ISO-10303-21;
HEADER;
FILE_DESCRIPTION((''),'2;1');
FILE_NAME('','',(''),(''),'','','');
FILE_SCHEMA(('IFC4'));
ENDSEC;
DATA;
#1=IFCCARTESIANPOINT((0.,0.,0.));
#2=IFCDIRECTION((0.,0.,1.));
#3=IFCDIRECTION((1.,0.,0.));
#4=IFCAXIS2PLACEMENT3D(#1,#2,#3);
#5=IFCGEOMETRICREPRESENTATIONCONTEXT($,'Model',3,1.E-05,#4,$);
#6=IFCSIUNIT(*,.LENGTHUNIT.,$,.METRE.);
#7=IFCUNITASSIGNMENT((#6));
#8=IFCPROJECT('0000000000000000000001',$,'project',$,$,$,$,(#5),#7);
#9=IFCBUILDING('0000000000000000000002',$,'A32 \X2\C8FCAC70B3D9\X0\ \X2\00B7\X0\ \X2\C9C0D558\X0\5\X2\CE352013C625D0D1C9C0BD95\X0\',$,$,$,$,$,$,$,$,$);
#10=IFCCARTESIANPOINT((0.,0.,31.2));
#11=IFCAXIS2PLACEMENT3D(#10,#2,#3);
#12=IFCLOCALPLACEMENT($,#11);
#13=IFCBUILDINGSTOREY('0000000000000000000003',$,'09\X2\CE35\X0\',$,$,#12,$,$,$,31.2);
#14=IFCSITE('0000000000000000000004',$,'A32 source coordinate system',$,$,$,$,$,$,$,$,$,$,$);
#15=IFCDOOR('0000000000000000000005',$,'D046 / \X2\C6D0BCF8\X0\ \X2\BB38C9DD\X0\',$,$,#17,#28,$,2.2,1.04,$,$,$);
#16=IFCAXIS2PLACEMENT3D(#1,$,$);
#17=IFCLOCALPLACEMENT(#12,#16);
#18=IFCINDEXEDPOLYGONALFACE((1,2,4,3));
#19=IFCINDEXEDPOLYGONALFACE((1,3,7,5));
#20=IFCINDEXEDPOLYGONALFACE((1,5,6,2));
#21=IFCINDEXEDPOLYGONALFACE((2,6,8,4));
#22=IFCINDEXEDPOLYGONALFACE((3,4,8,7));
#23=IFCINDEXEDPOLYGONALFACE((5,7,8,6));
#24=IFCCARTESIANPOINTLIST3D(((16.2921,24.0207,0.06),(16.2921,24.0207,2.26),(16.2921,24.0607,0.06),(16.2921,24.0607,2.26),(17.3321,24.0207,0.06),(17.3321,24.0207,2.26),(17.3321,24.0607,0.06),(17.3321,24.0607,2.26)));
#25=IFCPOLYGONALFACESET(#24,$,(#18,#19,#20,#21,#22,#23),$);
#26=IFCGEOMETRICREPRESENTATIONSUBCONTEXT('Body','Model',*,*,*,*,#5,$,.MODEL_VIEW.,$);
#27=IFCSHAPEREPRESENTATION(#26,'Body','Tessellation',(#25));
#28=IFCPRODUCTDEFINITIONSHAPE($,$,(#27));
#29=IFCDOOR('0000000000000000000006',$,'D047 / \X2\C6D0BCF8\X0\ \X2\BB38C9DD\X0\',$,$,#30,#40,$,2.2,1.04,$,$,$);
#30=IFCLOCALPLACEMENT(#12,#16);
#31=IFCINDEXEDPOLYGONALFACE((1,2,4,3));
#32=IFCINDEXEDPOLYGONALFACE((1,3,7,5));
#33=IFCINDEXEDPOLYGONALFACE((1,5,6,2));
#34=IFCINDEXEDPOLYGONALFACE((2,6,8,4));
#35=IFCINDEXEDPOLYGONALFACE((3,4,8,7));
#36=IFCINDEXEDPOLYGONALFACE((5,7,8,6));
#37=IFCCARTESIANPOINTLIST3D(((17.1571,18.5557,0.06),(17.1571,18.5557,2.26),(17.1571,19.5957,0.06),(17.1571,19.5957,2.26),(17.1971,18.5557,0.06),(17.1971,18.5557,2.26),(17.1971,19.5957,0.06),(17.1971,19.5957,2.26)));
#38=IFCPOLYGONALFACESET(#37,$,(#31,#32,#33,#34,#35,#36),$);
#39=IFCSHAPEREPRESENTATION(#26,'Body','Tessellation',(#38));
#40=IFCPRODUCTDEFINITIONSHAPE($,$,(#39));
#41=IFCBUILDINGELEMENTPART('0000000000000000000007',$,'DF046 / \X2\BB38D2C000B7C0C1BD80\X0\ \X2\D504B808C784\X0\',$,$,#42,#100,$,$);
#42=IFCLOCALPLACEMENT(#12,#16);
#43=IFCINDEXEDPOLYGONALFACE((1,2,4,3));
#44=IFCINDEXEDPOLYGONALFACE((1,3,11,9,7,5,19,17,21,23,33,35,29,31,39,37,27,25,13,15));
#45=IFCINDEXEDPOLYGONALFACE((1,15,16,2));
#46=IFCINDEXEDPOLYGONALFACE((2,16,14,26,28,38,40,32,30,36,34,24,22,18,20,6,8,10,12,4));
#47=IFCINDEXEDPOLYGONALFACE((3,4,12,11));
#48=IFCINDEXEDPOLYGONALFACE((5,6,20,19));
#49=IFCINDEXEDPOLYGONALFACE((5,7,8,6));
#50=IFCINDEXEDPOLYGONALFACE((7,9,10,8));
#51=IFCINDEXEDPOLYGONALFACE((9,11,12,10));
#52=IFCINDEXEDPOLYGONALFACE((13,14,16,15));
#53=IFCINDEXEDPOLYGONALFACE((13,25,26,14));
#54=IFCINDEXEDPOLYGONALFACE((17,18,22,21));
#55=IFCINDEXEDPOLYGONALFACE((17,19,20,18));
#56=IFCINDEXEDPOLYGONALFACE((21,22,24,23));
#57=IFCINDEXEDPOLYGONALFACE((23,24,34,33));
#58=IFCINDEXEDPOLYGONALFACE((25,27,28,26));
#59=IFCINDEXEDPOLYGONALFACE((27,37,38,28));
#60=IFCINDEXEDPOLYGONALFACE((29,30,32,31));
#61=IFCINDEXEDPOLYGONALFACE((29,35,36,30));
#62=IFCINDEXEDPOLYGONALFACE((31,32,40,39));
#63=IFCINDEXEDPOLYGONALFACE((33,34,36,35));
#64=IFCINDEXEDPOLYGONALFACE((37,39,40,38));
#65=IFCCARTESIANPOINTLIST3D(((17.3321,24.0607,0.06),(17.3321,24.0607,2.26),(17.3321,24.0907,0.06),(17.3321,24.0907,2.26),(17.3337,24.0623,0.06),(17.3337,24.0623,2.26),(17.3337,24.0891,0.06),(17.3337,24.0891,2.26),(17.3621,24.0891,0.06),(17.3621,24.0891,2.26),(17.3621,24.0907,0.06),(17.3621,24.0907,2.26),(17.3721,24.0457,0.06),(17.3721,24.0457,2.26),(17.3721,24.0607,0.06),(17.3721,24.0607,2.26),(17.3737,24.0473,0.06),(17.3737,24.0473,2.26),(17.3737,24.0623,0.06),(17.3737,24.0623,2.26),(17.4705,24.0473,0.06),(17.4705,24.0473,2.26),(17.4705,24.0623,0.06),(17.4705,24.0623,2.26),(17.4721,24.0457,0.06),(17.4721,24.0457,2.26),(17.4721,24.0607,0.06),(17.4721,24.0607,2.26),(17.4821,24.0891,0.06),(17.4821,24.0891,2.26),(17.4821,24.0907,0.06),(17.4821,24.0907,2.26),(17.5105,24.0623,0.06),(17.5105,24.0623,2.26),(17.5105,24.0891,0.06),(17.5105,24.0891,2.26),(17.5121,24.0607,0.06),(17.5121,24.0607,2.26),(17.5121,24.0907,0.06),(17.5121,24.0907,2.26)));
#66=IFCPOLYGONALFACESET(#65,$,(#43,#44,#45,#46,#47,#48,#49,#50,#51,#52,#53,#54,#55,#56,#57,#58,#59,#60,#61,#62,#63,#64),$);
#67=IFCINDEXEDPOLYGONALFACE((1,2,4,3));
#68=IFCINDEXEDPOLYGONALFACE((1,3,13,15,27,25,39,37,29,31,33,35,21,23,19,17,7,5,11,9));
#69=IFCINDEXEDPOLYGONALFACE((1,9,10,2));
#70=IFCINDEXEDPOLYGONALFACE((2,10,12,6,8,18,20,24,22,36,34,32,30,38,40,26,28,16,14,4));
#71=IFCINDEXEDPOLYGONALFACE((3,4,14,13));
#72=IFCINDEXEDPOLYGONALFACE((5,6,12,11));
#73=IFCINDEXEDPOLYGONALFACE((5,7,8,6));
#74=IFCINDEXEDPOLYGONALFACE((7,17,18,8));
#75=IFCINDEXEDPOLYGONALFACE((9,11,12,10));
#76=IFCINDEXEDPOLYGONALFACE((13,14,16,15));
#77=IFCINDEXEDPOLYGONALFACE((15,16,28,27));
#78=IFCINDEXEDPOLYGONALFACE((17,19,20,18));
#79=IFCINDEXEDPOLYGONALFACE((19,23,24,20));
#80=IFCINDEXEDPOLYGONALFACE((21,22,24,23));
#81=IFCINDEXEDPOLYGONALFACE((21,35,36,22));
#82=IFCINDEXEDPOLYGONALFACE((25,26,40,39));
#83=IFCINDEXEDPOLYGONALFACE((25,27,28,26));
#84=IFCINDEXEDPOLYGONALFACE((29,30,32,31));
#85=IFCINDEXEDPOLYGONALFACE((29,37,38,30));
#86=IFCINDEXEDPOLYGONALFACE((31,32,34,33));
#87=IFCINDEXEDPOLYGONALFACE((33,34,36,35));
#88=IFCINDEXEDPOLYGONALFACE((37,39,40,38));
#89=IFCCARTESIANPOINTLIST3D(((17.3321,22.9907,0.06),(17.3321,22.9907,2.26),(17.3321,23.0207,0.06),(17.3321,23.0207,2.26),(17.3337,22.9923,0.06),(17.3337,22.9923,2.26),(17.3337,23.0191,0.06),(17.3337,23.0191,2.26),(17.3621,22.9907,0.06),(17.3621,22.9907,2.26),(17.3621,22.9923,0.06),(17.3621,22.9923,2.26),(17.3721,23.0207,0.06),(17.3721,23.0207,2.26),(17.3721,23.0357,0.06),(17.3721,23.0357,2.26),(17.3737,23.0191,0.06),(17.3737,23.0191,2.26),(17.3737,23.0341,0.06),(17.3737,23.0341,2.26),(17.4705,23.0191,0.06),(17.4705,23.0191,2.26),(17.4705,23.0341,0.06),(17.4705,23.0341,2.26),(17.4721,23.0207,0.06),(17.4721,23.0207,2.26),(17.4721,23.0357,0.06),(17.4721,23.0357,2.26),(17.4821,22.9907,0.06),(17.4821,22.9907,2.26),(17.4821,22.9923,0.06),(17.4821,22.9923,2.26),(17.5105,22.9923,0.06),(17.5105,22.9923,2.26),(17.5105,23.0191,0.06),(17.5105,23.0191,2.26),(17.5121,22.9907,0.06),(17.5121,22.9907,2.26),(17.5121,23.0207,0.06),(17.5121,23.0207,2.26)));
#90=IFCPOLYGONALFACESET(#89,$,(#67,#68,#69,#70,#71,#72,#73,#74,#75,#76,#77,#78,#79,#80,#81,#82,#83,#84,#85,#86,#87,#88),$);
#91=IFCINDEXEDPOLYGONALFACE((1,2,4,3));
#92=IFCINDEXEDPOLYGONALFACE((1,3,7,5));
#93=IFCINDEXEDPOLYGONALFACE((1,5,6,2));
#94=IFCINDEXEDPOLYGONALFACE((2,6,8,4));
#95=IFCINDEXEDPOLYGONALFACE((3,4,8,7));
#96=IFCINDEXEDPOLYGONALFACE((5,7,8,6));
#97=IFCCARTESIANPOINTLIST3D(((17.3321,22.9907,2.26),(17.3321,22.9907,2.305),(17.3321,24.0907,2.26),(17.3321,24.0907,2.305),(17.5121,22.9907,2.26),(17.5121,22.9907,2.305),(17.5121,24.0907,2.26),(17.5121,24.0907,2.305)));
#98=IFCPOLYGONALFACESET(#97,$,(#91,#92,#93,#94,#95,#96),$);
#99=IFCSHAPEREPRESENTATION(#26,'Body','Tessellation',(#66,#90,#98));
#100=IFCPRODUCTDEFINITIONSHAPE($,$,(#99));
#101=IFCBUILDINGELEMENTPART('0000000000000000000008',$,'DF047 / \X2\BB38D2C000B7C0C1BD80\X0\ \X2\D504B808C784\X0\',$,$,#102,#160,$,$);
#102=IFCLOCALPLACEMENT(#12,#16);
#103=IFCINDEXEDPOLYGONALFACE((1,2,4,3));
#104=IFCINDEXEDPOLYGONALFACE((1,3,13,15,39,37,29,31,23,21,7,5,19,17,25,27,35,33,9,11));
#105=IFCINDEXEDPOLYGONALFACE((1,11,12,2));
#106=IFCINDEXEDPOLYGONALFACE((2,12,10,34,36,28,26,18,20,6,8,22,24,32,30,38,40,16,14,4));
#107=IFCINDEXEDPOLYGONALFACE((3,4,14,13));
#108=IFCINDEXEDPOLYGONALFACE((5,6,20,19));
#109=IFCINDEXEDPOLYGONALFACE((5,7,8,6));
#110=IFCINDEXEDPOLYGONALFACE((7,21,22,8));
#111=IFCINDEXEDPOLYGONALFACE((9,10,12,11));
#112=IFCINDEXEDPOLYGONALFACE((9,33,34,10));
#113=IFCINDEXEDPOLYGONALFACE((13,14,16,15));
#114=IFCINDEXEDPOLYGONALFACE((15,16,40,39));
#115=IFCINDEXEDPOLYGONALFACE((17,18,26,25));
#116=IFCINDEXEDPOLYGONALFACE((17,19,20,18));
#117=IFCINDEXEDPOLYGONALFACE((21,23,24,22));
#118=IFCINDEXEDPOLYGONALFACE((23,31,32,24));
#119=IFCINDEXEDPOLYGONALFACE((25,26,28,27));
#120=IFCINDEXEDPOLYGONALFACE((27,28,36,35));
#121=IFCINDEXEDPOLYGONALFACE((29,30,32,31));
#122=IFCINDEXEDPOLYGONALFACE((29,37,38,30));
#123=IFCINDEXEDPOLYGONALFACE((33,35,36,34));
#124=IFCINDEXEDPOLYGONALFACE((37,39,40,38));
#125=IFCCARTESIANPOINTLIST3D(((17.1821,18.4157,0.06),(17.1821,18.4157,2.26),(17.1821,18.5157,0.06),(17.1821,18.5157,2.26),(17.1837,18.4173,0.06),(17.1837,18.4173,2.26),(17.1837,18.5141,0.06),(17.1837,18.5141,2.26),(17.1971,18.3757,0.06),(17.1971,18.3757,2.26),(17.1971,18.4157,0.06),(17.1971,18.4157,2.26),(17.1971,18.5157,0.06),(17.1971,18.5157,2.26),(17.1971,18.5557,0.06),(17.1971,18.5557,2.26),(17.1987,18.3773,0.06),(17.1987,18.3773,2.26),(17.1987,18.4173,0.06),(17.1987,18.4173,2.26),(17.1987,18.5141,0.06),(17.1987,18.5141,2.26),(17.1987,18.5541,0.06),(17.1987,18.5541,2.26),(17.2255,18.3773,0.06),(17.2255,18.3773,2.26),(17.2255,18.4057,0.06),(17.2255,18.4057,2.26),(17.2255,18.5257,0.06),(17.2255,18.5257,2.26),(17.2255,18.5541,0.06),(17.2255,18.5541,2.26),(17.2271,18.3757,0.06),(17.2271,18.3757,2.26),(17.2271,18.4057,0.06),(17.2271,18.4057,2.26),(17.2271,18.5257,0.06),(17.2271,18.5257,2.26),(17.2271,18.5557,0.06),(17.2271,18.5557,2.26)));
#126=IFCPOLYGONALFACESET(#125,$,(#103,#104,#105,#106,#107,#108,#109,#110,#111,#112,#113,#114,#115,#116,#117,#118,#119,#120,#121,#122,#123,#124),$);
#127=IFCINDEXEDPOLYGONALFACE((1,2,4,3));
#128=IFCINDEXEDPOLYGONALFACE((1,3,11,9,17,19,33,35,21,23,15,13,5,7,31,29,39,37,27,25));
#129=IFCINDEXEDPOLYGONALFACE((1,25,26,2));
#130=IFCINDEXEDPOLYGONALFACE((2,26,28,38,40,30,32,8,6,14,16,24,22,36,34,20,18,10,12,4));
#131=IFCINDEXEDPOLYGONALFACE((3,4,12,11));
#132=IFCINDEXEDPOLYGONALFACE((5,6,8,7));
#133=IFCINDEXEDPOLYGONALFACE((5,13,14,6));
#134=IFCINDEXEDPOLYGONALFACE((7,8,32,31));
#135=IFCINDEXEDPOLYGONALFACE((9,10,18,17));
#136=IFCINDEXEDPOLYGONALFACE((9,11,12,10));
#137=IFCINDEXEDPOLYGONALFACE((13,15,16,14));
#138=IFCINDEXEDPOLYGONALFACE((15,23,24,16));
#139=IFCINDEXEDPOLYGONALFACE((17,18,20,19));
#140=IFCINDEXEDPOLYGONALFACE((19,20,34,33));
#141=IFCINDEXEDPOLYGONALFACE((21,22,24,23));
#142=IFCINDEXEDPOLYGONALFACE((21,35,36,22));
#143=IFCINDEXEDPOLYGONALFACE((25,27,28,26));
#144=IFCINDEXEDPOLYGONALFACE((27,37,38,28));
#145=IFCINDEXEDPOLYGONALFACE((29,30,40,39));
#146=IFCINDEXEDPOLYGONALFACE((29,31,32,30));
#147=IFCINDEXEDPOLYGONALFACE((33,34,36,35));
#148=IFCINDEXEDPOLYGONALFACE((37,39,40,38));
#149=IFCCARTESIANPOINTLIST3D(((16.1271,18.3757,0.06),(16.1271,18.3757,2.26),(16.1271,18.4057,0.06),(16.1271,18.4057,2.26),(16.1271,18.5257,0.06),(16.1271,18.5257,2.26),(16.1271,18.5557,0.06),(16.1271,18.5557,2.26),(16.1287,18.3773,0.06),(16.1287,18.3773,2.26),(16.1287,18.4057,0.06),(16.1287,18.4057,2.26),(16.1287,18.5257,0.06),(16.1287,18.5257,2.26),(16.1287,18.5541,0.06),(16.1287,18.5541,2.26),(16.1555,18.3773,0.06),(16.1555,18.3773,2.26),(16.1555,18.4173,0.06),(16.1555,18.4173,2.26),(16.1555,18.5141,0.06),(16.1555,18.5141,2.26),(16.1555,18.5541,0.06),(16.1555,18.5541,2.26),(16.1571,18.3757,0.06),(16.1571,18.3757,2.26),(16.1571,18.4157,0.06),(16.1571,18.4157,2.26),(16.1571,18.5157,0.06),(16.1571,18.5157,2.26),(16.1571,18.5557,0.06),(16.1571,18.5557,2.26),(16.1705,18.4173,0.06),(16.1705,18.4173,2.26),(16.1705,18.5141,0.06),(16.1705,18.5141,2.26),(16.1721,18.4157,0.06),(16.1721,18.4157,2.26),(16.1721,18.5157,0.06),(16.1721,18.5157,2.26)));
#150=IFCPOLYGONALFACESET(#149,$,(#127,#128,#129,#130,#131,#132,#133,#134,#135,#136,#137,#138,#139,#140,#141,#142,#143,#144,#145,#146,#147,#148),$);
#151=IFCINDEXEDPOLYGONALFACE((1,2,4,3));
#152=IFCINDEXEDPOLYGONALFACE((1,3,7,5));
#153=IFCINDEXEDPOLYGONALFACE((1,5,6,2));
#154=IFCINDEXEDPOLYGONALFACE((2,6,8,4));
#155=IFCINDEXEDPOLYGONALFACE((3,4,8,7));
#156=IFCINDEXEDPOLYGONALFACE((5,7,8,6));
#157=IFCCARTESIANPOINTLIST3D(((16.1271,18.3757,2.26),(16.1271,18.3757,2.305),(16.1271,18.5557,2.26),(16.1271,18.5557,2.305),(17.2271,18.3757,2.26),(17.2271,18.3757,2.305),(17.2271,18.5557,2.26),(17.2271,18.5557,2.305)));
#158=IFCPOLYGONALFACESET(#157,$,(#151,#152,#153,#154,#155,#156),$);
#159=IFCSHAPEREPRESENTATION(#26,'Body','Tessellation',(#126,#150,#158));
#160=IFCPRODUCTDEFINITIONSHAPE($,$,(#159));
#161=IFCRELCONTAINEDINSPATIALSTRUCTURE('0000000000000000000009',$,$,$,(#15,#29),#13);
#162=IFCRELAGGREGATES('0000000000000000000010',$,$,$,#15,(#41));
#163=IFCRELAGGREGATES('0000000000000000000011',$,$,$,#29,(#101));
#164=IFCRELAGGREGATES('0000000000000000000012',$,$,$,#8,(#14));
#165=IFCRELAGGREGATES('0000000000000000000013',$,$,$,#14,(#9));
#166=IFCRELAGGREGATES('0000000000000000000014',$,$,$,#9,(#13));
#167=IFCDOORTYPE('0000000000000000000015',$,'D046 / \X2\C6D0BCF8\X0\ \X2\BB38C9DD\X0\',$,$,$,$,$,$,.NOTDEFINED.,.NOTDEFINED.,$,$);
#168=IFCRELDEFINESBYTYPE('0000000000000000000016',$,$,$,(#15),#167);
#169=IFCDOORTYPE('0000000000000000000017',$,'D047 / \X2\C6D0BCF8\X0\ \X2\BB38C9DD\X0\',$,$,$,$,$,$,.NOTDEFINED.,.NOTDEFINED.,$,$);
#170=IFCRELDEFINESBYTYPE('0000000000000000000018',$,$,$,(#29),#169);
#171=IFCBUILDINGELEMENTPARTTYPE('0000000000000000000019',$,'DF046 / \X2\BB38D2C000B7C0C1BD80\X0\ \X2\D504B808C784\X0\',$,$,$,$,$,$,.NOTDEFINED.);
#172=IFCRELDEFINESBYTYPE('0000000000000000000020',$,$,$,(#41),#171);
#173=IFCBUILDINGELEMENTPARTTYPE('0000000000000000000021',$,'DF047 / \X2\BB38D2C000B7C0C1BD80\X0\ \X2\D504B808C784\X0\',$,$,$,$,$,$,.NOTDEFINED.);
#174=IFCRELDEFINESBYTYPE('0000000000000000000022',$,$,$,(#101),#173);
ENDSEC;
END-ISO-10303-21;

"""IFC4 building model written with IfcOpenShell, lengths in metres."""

from ifc_helpers import new_model, si_unit, frame, origin, origin_with_axes, place, context, subcontext, project, spatial, polyline, outline, extrude, source, transform, mapped, type_object, type_shapes, element, aggregate, save


model = new_model("IFC4")

# Units and contexts
model_context = context("Model", 3, precision=1e-05, world=origin_with_axes())
body_context = subcontext(model_context, "Body", "Model", "MODEL_VIEW")
ifc_project = project(units=[si_unit("LENGTHUNIT", "METRE")], contexts=[model_context])

# Site, building, storey
storey_placement = place(None, frame((0.0, 0.0, 31.2), z_axis=(0.0, 0.0, 1.0), x_axis=(1.0, 0.0, 0.0)))
site = spatial("IfcSite", under=ifc_project, Name="A32 source coordinate system")
building = spatial("IfcBuilding", under=site, Name="A32 주거동 · 지하5층–옥탑지붕")
storey = spatial("IfcBuildingStorey", under=building, at=storey_placement, Name="09층", Elevation=31.2)

# Doors
door_type_1 = type_object("IfcDoorType", Name="D046 / 원본 문짝", OperationType="NOTDEFINED", PredefinedType="NOTDEFINED")
shared_shape_1 = source(origin(), body_context, "Body", "SweptSolid", [
    extrude(outline(polyline([(17.3321, 24.0607), (17.3321, 24.0207), (16.2921, 24.0207), (16.2921, 24.0607), (17.3321, 24.0607)])), frame((0.0, 0.0, 0.06)), (0.0, 0.0, 1.0), 2.2),
])
type_shapes(door_type_1, [shared_shape_1])
door_1_placement = place(storey_placement, origin_with_axes())
door_1 = element("IfcDoor", 1, at=door_1_placement, inside=storey, type_object=door_type_1, Name="D046 / 원본 문짝", OverallHeight=2.2, OverallWidth=1.04, context=body_context, shape_type="MappedRepresentation", body=[
    mapped(shared_shape_1, transform((0.0, 0.0, 0.0), scale=1.0)),
])
door_type_2 = type_object("IfcDoorType", Name="D047 / 원본 문짝", OperationType="NOTDEFINED", PredefinedType="NOTDEFINED")
shared_shape_2 = source(origin(), body_context, "Body", "SweptSolid", [
    extrude(outline(polyline([(17.1971, 18.5557), (17.1571, 18.5557), (17.1571, 19.5957), (17.1971, 19.5957), (17.1971, 18.5557)])), frame((0.0, 0.0, 0.06)), (0.0, 0.0, 1.0), 2.2),
])
type_shapes(door_type_2, [shared_shape_2])
door_2_placement = place(storey_placement, origin_with_axes())
door_2 = element("IfcDoor", 2, at=door_2_placement, inside=storey, type_object=door_type_2, Name="D047 / 원본 문짝", OverallHeight=2.2, OverallWidth=1.04, context=body_context, shape_type="MappedRepresentation", body=[
    mapped(shared_shape_2, transform((0.0, 0.0, 0.0), scale=1.0)),
])

# Building element parts
building_element_part_type_1 = type_object("IfcBuildingElementPartType", Name="DF046 / 문틀·상부 프레임", PredefinedType="NOTDEFINED")
shared_shape_3 = source(origin(), body_context, "Body", "SweptSolid", [
    extrude(outline(polyline([(17.3337, 24.0891), (17.3337, 24.0623), (17.3737, 24.0623), (17.3737, 24.0473), (17.4705, 24.0473), (17.4705, 24.0623), (17.5105, 24.0623), (17.5105, 24.0891), (17.4821, 24.0891), (17.4821, 24.0907), (17.5121, 24.0907), (17.5121, 24.0607), (17.4721, 24.0607), (17.4721, 24.0457), (17.3721, 24.0457), (17.3721, 24.0607), (17.3321, 24.0607), (17.3321, 24.0907), (17.3621, 24.0907), (17.3621, 24.0891), (17.3337, 24.0891)])), frame((0.0, 0.0, 0.06)), (0.0, 0.0, 1.0), 2.2),
    extrude(outline(polyline([(17.3621, 22.9907), (17.3321, 22.9907), (17.3321, 23.0207), (17.3721, 23.0207), (17.3721, 23.0357), (17.4721, 23.0357), (17.4721, 23.0207), (17.5121, 23.0207), (17.5121, 22.9907), (17.4821, 22.9907), (17.4821, 22.9923), (17.5105, 22.9923), (17.5105, 23.0191), (17.4705, 23.0191), (17.4705, 23.0341), (17.3737, 23.0341), (17.3737, 23.0191), (17.3337, 23.0191), (17.3337, 22.9923), (17.3621, 22.9923), (17.3621, 22.9907)])), frame((0.0, 0.0, 0.06)), (0.0, 0.0, 1.0), 2.2),
    extrude(outline(polyline([(17.3321, 22.9907), (17.3321, 24.0907), (17.5121, 24.0907), (17.5121, 22.9907), (17.3321, 22.9907)])), frame((0.0, 0.0, 2.26)), (0.0, 0.0, 1.0), 0.045),
])
type_shapes(building_element_part_type_1, [shared_shape_3])
building_element_part_1_placement = place(door_1_placement, origin_with_axes())
building_element_part_1 = element("IfcBuildingElementPart", 3, at=building_element_part_1_placement, type_object=building_element_part_type_1, Name="DF046 / 문틀·상부 프레임", context=body_context, shape_type="MappedRepresentation", body=[
    mapped(shared_shape_3, transform((0.0, 0.0, 0.0), scale=1.0)),
])
aggregate(door_1, [building_element_part_1])
building_element_part_type_2 = type_object("IfcBuildingElementPartType", Name="DF047 / 문틀·상부 프레임", PredefinedType="NOTDEFINED")
shared_shape_4 = source(origin(), body_context, "Body", "SweptSolid", [
    extrude(outline(polyline([(17.2255, 18.5541), (17.1987, 18.5541), (17.1987, 18.5141), (17.1837, 18.5141), (17.1837, 18.4173), (17.1987, 18.4173), (17.1987, 18.3773), (17.2255, 18.3773), (17.2255, 18.4057), (17.2271, 18.4057), (17.2271, 18.3757), (17.1971, 18.3757), (17.1971, 18.4157), (17.1821, 18.4157), (17.1821, 18.5157), (17.1971, 18.5157), (17.1971, 18.5557), (17.2271, 18.5557), (17.2271, 18.5257), (17.2255, 18.5257), (17.2255, 18.5541)])), frame((0.0, 0.0, 0.06)), (0.0, 0.0, 1.0), 2.2),
    extrude(outline(polyline([(16.1271, 18.5257), (16.1271, 18.5557), (16.1571, 18.5557), (16.1571, 18.5157), (16.1721, 18.5157), (16.1721, 18.4157), (16.1571, 18.4157), (16.1571, 18.3757), (16.1271, 18.3757), (16.1271, 18.4057), (16.1287, 18.4057), (16.1287, 18.3773), (16.1555, 18.3773), (16.1555, 18.4173), (16.1705, 18.4173), (16.1705, 18.5141), (16.1555, 18.5141), (16.1555, 18.5541), (16.1287, 18.5541), (16.1287, 18.5257), (16.1271, 18.5257)])), frame((0.0, 0.0, 0.06)), (0.0, 0.0, 1.0), 2.2),
    extrude(outline(polyline([(16.1271, 18.3757), (16.1271, 18.5557), (17.2271, 18.5557), (17.2271, 18.3757), (16.1271, 18.3757)])), frame((0.0, 0.0, 2.26)), (0.0, 0.0, 1.0), 0.045),
])
type_shapes(building_element_part_type_2, [shared_shape_4])
building_element_part_2_placement = place(door_2_placement, origin_with_axes())
building_element_part_2 = element("IfcBuildingElementPart", 4, at=building_element_part_2_placement, type_object=building_element_part_type_2, Name="DF047 / 문틀·상부 프레임", context=body_context, shape_type="MappedRepresentation", body=[
    mapped(shared_shape_4, transform((0.0, 0.0, 0.0), scale=1.0)),
])
aggregate(door_2, [building_element_part_2])

save(model, "model.ifc")
